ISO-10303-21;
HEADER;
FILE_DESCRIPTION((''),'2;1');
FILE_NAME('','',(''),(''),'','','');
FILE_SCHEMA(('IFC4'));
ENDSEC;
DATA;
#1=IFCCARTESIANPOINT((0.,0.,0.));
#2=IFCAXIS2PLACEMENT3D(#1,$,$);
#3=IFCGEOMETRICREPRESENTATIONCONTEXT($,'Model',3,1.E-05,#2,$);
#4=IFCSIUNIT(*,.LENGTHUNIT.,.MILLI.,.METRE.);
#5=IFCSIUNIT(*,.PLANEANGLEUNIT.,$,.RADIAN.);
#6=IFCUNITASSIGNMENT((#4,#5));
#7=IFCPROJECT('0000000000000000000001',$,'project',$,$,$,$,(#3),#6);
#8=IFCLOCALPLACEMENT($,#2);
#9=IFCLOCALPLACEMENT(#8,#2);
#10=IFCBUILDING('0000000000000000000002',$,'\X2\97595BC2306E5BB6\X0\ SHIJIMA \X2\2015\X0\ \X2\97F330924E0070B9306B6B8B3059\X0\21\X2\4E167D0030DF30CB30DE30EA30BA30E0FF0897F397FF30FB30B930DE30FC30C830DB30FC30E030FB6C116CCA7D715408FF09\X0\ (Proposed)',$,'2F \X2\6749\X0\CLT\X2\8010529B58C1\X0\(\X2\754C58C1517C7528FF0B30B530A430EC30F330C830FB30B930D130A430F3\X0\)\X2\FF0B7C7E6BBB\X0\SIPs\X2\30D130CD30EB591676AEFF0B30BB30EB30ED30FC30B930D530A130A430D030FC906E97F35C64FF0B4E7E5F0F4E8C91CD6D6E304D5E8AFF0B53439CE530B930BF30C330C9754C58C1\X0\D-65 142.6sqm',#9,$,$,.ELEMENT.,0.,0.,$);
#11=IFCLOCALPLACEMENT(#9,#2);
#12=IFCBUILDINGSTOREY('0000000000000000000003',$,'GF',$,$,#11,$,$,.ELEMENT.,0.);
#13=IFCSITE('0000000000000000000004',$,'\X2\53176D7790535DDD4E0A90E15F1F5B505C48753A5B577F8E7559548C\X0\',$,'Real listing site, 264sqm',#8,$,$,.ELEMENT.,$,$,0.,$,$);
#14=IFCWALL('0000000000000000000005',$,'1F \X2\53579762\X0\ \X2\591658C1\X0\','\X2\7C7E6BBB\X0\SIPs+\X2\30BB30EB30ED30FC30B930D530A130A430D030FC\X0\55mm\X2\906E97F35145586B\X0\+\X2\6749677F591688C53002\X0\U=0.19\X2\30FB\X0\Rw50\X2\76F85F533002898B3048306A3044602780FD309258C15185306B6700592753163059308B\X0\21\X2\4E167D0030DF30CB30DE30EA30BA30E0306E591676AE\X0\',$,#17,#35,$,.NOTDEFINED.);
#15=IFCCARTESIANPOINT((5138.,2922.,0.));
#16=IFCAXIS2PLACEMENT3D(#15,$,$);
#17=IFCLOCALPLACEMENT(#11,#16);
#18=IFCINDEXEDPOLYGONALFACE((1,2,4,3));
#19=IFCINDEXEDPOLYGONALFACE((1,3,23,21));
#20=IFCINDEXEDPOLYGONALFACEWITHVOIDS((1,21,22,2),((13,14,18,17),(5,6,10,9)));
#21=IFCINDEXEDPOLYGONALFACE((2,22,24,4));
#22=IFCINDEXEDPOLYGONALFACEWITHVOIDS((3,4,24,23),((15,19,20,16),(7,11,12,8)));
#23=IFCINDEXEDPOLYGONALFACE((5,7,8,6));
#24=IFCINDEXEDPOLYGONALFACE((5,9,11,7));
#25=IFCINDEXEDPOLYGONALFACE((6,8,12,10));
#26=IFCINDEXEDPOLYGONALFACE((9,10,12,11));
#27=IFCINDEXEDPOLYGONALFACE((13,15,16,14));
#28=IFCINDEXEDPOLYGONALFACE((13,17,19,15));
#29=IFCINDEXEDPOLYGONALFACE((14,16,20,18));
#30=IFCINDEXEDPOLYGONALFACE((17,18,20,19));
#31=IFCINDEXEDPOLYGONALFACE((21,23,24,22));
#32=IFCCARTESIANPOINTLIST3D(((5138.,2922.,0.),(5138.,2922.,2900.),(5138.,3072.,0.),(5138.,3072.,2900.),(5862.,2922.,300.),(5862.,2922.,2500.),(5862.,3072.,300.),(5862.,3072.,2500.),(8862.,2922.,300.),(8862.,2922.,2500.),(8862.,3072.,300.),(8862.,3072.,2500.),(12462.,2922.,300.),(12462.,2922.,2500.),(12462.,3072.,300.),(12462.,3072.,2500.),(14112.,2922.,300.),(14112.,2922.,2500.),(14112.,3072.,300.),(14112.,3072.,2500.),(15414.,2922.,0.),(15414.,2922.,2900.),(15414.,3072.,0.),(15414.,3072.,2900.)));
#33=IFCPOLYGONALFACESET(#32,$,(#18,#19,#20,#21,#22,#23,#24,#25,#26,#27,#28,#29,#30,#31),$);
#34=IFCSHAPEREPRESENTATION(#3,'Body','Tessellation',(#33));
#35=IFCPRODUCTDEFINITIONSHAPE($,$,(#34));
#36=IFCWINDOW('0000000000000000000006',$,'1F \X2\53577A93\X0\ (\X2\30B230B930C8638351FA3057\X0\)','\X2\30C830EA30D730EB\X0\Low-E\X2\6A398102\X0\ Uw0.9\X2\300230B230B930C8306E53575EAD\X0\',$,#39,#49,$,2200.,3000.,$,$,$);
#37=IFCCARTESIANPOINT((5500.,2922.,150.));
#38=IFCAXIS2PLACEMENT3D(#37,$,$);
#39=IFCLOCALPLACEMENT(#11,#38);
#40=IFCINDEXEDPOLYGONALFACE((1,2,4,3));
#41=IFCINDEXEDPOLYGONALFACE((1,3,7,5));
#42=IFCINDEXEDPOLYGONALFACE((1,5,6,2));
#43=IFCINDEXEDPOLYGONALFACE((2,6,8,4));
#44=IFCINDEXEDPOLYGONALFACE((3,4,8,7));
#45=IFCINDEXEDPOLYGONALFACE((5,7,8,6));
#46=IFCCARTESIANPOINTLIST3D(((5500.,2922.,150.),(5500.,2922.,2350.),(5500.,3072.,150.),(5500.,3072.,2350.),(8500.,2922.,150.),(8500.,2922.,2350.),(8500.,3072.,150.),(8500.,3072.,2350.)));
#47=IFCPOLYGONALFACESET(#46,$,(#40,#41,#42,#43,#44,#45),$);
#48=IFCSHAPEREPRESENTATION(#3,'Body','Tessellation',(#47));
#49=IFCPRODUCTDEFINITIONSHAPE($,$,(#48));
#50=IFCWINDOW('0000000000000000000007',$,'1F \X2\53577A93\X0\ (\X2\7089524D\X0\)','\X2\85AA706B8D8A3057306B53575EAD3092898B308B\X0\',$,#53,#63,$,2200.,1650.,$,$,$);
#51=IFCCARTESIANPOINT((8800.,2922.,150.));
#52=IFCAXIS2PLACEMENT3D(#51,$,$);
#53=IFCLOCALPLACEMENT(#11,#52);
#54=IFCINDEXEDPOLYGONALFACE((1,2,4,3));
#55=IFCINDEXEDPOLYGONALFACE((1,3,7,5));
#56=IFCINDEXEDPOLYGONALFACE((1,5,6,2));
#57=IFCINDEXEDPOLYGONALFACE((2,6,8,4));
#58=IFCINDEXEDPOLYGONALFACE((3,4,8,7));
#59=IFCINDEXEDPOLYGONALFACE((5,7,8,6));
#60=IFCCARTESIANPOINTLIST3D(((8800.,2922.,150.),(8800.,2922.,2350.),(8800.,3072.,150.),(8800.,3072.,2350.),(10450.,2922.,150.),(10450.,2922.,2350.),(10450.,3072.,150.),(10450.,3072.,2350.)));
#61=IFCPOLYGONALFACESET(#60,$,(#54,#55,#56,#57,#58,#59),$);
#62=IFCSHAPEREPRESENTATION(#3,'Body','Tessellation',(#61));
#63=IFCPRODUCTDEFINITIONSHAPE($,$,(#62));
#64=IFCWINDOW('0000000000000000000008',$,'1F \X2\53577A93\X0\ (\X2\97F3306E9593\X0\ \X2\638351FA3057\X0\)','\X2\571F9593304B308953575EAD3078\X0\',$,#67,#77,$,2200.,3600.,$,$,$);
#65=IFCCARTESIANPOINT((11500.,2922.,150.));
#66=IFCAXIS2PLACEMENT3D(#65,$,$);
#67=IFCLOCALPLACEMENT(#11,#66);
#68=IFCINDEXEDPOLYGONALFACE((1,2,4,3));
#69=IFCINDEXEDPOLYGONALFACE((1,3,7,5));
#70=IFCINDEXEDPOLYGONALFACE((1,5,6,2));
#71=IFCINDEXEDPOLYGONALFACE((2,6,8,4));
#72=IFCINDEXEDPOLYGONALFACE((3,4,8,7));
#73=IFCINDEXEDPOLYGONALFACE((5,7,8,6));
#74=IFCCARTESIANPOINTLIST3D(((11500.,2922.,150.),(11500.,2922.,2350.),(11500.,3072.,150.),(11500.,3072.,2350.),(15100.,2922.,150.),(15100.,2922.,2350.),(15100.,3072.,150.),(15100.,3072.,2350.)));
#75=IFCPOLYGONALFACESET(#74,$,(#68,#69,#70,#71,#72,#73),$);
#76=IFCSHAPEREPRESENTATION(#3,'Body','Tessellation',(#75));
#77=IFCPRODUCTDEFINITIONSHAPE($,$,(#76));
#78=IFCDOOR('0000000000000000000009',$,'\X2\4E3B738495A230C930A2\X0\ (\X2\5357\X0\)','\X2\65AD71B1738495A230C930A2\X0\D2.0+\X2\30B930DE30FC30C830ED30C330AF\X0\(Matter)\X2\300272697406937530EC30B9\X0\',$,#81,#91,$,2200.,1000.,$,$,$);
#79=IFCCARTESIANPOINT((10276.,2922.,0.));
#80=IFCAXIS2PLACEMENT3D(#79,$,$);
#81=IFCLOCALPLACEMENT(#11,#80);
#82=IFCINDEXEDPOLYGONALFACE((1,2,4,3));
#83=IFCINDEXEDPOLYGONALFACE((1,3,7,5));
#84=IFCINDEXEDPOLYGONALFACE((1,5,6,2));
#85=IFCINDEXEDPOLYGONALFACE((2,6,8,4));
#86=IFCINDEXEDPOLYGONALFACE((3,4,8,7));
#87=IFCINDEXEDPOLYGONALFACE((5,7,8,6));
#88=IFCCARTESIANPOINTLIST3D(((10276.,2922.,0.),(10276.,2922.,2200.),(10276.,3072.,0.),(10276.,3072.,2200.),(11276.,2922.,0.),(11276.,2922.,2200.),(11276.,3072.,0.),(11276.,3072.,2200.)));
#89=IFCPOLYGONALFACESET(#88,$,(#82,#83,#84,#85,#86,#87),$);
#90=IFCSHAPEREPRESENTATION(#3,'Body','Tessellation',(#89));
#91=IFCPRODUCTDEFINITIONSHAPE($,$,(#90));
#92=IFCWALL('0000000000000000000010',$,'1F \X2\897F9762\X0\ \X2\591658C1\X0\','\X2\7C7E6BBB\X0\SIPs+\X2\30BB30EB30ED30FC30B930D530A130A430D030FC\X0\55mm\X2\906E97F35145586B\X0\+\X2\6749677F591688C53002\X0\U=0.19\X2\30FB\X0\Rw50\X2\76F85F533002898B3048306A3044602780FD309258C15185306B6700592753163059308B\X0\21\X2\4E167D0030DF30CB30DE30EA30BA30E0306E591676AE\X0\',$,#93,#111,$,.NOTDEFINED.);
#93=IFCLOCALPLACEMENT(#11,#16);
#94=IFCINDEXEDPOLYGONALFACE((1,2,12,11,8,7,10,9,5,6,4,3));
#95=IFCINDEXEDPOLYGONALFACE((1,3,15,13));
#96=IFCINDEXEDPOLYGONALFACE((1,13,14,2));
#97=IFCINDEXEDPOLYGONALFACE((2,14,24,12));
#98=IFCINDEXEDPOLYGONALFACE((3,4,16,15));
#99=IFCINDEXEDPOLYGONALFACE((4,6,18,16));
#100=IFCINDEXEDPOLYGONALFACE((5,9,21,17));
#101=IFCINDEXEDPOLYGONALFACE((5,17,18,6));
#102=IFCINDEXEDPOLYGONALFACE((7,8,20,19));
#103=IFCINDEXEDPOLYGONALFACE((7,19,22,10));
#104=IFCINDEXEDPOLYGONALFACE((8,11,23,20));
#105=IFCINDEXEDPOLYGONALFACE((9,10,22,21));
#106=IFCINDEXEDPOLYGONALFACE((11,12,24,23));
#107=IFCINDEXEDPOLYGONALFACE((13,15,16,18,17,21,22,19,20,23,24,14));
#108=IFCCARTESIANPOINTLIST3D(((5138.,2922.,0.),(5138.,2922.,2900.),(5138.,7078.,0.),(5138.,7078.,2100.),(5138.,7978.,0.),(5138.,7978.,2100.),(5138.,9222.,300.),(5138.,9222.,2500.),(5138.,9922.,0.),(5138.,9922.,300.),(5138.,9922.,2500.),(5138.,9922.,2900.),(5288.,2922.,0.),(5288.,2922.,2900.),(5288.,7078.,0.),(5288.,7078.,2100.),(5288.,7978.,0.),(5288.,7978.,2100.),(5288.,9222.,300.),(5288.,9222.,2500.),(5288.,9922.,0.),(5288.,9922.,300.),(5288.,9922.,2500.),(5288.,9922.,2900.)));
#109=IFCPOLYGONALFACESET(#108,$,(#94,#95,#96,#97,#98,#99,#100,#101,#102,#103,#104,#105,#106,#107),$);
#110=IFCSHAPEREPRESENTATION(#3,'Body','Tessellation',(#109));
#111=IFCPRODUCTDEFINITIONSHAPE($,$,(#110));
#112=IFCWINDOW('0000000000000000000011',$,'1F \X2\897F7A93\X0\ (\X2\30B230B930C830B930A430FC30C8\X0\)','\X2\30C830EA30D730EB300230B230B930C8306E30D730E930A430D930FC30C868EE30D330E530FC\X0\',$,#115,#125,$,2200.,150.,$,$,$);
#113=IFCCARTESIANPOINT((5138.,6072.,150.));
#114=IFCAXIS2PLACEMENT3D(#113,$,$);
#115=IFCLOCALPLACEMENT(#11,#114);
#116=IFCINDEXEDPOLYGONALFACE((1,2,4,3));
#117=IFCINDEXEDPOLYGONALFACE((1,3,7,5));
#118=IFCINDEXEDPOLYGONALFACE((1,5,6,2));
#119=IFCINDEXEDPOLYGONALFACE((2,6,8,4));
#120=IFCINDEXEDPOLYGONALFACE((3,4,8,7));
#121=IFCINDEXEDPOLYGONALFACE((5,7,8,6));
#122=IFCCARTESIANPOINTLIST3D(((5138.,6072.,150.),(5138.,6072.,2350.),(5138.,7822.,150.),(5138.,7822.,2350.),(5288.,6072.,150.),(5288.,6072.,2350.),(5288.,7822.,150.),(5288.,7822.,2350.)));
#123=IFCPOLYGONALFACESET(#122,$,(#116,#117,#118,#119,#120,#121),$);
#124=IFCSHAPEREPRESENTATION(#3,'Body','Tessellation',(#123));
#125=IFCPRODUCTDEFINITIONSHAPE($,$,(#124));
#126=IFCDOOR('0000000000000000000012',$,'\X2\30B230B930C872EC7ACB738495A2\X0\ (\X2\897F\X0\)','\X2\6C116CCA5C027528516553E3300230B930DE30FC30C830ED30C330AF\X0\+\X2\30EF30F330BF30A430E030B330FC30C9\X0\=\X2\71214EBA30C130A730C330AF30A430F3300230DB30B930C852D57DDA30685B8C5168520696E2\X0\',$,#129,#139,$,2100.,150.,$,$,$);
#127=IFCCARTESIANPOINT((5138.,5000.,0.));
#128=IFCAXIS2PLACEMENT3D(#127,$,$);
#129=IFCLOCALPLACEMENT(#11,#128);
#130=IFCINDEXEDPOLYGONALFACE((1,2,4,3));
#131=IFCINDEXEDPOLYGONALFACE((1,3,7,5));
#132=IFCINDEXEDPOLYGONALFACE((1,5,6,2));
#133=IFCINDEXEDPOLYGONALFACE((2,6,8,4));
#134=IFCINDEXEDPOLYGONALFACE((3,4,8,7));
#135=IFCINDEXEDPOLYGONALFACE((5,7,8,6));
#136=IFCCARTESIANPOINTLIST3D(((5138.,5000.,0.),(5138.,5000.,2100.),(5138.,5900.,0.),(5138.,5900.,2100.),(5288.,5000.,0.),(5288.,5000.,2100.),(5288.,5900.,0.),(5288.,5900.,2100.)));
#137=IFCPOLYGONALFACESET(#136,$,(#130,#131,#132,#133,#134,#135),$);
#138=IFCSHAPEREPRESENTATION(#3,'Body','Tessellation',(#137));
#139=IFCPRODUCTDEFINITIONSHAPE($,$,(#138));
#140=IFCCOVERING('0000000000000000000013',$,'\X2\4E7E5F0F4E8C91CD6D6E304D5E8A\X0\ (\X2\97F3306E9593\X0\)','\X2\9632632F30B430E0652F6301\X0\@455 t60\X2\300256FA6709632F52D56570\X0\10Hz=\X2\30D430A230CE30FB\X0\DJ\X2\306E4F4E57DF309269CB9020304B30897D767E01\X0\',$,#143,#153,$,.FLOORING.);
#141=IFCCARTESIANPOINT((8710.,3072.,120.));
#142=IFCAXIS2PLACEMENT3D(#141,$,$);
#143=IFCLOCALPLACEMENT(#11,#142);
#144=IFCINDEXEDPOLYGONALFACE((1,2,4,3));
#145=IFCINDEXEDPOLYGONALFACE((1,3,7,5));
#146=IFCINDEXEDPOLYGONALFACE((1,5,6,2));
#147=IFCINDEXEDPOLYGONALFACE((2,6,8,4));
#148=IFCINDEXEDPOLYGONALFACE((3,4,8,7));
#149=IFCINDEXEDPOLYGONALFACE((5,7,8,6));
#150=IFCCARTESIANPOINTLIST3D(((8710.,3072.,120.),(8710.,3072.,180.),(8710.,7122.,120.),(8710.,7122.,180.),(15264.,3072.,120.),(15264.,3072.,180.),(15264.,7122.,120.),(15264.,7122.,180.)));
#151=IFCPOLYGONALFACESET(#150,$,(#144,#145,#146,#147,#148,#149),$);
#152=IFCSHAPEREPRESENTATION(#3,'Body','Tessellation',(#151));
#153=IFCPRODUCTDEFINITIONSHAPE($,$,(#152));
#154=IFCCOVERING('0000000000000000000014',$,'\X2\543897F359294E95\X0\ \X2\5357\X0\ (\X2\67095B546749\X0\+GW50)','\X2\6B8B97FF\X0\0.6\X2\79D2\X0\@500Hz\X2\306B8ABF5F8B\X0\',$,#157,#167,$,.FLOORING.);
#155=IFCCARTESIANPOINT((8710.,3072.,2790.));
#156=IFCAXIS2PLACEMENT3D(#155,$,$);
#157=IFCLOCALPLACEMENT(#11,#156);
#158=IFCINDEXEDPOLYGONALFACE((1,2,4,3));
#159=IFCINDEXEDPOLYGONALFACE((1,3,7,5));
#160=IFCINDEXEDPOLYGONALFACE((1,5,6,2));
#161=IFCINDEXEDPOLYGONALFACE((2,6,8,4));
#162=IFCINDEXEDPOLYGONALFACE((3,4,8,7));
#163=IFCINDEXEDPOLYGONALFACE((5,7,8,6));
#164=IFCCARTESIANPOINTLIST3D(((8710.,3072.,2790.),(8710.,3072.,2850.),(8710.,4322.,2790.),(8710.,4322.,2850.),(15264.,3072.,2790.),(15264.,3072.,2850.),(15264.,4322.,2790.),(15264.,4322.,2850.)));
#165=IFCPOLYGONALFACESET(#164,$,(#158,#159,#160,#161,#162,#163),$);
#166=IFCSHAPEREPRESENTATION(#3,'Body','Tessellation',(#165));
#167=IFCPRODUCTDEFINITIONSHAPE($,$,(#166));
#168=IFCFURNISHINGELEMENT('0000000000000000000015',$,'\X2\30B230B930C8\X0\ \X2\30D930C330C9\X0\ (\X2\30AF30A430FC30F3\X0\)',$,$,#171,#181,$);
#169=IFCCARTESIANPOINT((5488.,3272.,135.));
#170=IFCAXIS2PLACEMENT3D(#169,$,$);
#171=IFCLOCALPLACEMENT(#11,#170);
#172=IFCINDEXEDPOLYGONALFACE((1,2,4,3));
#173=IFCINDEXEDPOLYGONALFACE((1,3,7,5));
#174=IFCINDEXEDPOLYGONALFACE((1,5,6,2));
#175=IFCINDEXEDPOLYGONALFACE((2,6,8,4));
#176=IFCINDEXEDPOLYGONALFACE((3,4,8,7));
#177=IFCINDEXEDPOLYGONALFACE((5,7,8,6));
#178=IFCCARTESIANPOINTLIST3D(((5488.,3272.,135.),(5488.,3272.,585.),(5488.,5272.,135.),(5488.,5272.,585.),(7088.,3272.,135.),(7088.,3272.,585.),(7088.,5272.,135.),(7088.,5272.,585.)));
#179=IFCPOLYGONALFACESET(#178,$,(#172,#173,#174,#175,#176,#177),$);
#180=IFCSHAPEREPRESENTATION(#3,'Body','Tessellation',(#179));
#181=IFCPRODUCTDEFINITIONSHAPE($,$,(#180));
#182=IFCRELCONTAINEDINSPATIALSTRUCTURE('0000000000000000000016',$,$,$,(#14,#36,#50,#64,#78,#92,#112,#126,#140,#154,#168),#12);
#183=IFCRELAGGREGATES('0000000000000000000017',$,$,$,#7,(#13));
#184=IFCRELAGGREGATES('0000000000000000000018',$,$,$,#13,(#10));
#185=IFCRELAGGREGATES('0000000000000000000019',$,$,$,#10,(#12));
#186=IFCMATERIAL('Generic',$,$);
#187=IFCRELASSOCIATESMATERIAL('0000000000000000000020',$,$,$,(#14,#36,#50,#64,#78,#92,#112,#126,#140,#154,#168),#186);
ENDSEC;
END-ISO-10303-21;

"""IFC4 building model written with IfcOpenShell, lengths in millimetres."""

from ifc_helpers import new_model, si_unit, frame, frame_2d, origin, place, context, project, spatial, rectangle, extrude, material, element, fill, save


model = new_model("IFC4")

# Units and contexts
model_context = context("Model", 3, precision=1e-05, world=origin())
ifc_project = project(units=[si_unit("LENGTHUNIT", "METRE", prefix="MILLI"), si_unit("PLANEANGLEUNIT", "RADIAN")], contexts=[model_context])

# Site, building, storey
site_placement = place(None, origin())
site = spatial("IfcSite", under=ifc_project, at=site_placement, Name="北海道川上郡弟子屈町字美留和", ObjectType="Real listing site, 264sqm", CompositionType="ELEMENT", RefElevation=0.0)
building_placement = place(site_placement, origin())
building = spatial("IfcBuilding", under=site, at=building_placement, Name="静寂の家 SHIJIMA ― 音を一点に残す21世紀ミニマリズム（音響・スマートホーム・民泊統合） (Proposed)", ObjectType="2F 杉CLT耐力壁(界壁兼用＋サイレント・スパイン)＋籾殻SIPsパネル外皮＋セルロースファイバー遮音層＋乾式二重浮き床＋千鳥スタッド界壁D-65 142.6sqm", CompositionType="ELEMENT", ElevationOfRefHeight=0.0, ElevationOfTerrain=0.0)
storey_placement = place(building_placement, origin())
storey = spatial("IfcBuildingStorey", under=building, at=storey_placement, Name="GF", CompositionType="ELEMENT", Elevation=0.0)

# Shared definitions
ifc_material_1 = material(Name="Generic")

# Wall, openings, windows, door
wall_1_placement = place(storey_placement, frame((5138.0, 2922.0, 0.0)))
wall_1 = element("IfcWall", 1, at=wall_1_placement, inside=storey, material=ifc_material_1, Name="1F 南面 外壁", Description="籾殻SIPs+セルロースファイバー55mm遮音充填+杉板外装。U=0.19・Rw50相当。見えない性能を壁内に最大化する21世紀ミニマリズムの外皮", PredefinedType="NOTDEFINED", context=model_context, shape_type="SweptSolid", body=[
    extrude(rectangle(XDim=10276.0, YDim=150.0, at=frame_2d((5138.0, 75.0))), frame((5138.0, 2922.0, 0.0)), (0.0, 0.0, 1.0), 2900.0),
])
opening_1_placement = place(storey_placement, frame((5500.0, 2922.0, 150.0)))
opening_1 = element("IfcOpeningElement", 2, at=opening_1_placement, cuts=wall_1, PredefinedType="NOTDEFINED", context=model_context, shape_type="SweptSolid", body=[
    extrude(rectangle(XDim=3000.0, YDim=150.0, at=frame_2d((1500.0, 75.0))), frame((5500.0, 2922.0, 150.0)), (0.0, 0.0, 1.0), 2200.0),
])
opening_2_placement = place(storey_placement, frame((8800.0, 2922.0, 150.0)))
opening_2 = element("IfcOpeningElement", 3, at=opening_2_placement, cuts=wall_1, PredefinedType="NOTDEFINED", context=model_context, shape_type="SweptSolid", body=[
    extrude(rectangle(XDim=1650.0, YDim=150.0, at=frame_2d((825.0, 75.0))), frame((8800.0, 2922.0, 150.0)), (0.0, 0.0, 1.0), 2200.0),
])
opening_3_placement = place(storey_placement, frame((11500.0, 2922.0, 150.0)))
opening_3 = element("IfcOpeningElement", 4, at=opening_3_placement, cuts=wall_1, PredefinedType="NOTDEFINED", context=model_context, shape_type="SweptSolid", body=[
    extrude(rectangle(XDim=3600.0, YDim=150.0, at=frame_2d((1800.0, 75.0))), frame((11500.0, 2922.0, 150.0)), (0.0, 0.0, 1.0), 2200.0),
])
opening_4_placement = place(storey_placement, frame((10276.0, 2922.0, 0.0)))
opening_4 = element("IfcOpeningElement", 5, at=opening_4_placement, cuts=wall_1, PredefinedType="NOTDEFINED", context=model_context, shape_type="SweptSolid", body=[
    extrude(rectangle(XDim=1000.0, YDim=150.0, at=frame_2d((500.0, 75.0))), frame((10276.0, 2922.0, 0.0)), (0.0, 0.0, 1.0), 2200.0),
])
window_1_placement = place(storey_placement, frame((5500.0, 2922.0, 150.0)))
window_1 = element("IfcWindow", 6, at=window_1_placement, inside=storey, material=ifc_material_1, Name="1F 南窓 (ゲスト掃出し)", Description="トリプルLow-E樹脂 Uw0.9。ゲストの南庭", OverallHeight=2200.0, OverallWidth=3000.0, context=model_context, shape_type="SweptSolid", body=[
    extrude(rectangle(XDim=3000.0, YDim=150.0, at=frame_2d((1500.0, 75.0))), frame((5500.0, 2922.0, 150.0)), (0.0, 0.0, 1.0), 2200.0),
])
fill(opening_1, window_1)
window_2_placement = place(storey_placement, frame((8800.0, 2922.0, 150.0)))
window_2 = element("IfcWindow", 7, at=window_2_placement, inside=storey, material=ifc_material_1, Name="1F 南窓 (炉前)", Description="薪火越しに南庭を見る", OverallHeight=2200.0, OverallWidth=1650.0, context=model_context, shape_type="SweptSolid", body=[
    extrude(rectangle(XDim=1650.0, YDim=150.0, at=frame_2d((825.0, 75.0))), frame((8800.0, 2922.0, 150.0)), (0.0, 0.0, 1.0), 2200.0),
])
fill(opening_2, window_2)
window_3_placement = place(storey_placement, frame((11500.0, 2922.0, 150.0)))
window_3 = element("IfcWindow", 8, at=window_3_placement, inside=storey, material=ifc_material_1, Name="1F 南窓 (音の間 掃出し)", Description="土間から南庭へ", OverallHeight=2200.0, OverallWidth=3600.0, context=model_context, shape_type="SweptSolid", body=[
    extrude(rectangle(XDim=3600.0, YDim=150.0, at=frame_2d((1800.0, 75.0))), frame((11500.0, 2922.0, 150.0)), (0.0, 0.0, 1.0), 2200.0),
])
fill(opening_3, window_3)
door_1_placement = place(storey_placement, frame((10276.0, 2922.0, 0.0)))
door_1 = element("IfcDoor", 9, at=door_1_placement, inside=storey, material=ifc_material_1, Name="主玄関ドア (南)", Description="断熱玄関ドアD2.0+スマートロック(Matter)。物理鍵レス", OverallHeight=2200.0, OverallWidth=1000.0, context=model_context, shape_type="SweptSolid", body=[
    extrude(rectangle(XDim=1000.0, YDim=150.0, at=frame_2d((500.0, 75.0))), frame((10276.0, 2922.0, 0.0)), (0.0, 0.0, 1.0), 2200.0),
])
fill(opening_4, door_1)

# Wall, openings, window, door
wall_2_placement = place(storey_placement, frame((5138.0, 2922.0, 0.0)))
wall_2 = element("IfcWall", 10, at=wall_2_placement, inside=storey, material=ifc_material_1, Name="1F 西面 外壁", Description="籾殻SIPs+セルロースファイバー55mm遮音充填+杉板外装。U=0.19・Rw50相当。見えない性能を壁内に最大化する21世紀ミニマリズムの外皮", PredefinedType="NOTDEFINED", context=model_context, shape_type="SweptSolid", body=[
    extrude(rectangle(XDim=150.0, YDim=7000.0, at=frame_2d((75.0, 3500.0))), frame((5138.0, 2922.0, 0.0)), (0.0, 0.0, 1.0), 2900.0),
])
opening_5_placement = place(storey_placement, frame((5138.0, 6072.0, 150.0)))
opening_5 = element("IfcOpeningElement", 11, at=opening_5_placement, cuts=wall_2, PredefinedType="NOTDEFINED", context=model_context, shape_type="SweptSolid", body=[
    extrude(rectangle(XDim=150.0, YDim=1750.0, at=frame_2d((75.0, 875.0))), frame((5138.0, 6072.0, 150.0)), (0.0, 0.0, 1.0), 2200.0),
])
opening_6_placement = place(storey_placement, frame((5138.0, 5000.0, 0.0)))
opening_6 = element("IfcOpeningElement", 12, at=opening_6_placement, cuts=wall_2, PredefinedType="NOTDEFINED", context=model_context, shape_type="SweptSolid", body=[
    extrude(rectangle(XDim=150.0, YDim=900.0, at=frame_2d((75.0, 450.0))), frame((5138.0, 5000.0, 0.0)), (0.0, 0.0, 1.0), 2100.0),
])
window_4_placement = place(storey_placement, frame((5138.0, 6072.0, 150.0)))
window_4 = element("IfcWindow", 13, at=window_4_placement, inside=storey, material=ifc_material_1, Name="1F 西窓 (ゲストスイート)", Description="トリプル。ゲストのプライベート森ビュー", OverallHeight=2200.0, OverallWidth=150.0, context=model_context, shape_type="SweptSolid", body=[
    extrude(rectangle(XDim=150.0, YDim=1750.0, at=frame_2d((75.0, 875.0))), frame((5138.0, 6072.0, 150.0)), (0.0, 0.0, 1.0), 2200.0),
])
fill(opening_5, window_4)
door_2_placement = place(storey_placement, frame((5138.0, 5000.0, 0.0)))
door_2 = element("IfcDoor", 14, at=door_2_placement, inside=storey, material=ifc_material_1, Name="ゲスト独立玄関 (西)", Description="民泊専用入口。スマートロック+ワンタイムコード=無人チェックイン。ホスト動線と完全分離", OverallHeight=2100.0, OverallWidth=150.0, context=model_context, shape_type="SweptSolid", body=[
    extrude(rectangle(XDim=150.0, YDim=900.0, at=frame_2d((75.0, 450.0))), frame((5138.0, 5000.0, 0.0)), (0.0, 0.0, 1.0), 2100.0),
])
fill(opening_6, door_2)

# Coverings
covering_1_placement = place(storey_placement, frame((8710.0, 3072.0, 120.0)))
element("IfcCovering", 15, at=covering_1_placement, inside=storey, material=ifc_material_1, Name="乾式二重浮き床 (音の間)", Description="防振ゴム支持@455 t60。固有振動数10Hz=ピアノ・DJの低域を構造から絶縁", PredefinedType="FLOORING", context=model_context, shape_type="SweptSolid", body=[
    extrude(rectangle(XDim=6554.0, YDim=4050.0, at=frame_2d((3277.0, 2025.0))), frame((8710.0, 3072.0, 120.0)), (0.0, 0.0, 1.0), 60.0),
])
covering_2_placement = place(storey_placement, frame((8710.0, 3072.0, 2790.0)))
element("IfcCovering", 16, at=covering_2_placement, inside=storey, material=ifc_material_1, Name="吸音天井 南 (有孔杉+GW50)", Description="残響0.6秒@500Hzに調律", PredefinedType="FLOORING", context=model_context, shape_type="SweptSolid", body=[
    extrude(rectangle(XDim=6554.0, YDim=1250.0, at=frame_2d((3277.0, 625.0))), frame((8710.0, 3072.0, 2790.0)), (0.0, 0.0, 1.0), 60.0),
])

# Furnishing element
furnishing_1_placement = place(storey_placement, frame((5488.0, 3272.0, 135.0)))
element("IfcFurnishingElement", 17, at=furnishing_1_placement, inside=storey, material=ifc_material_1, Name="ゲスト ベッド (クイーン)", context=model_context, shape_type="SweptSolid", body=[
    extrude(rectangle(XDim=1600.0, YDim=2000.0, at=frame_2d((800.0, 1000.0))), frame((5488.0, 3272.0, 135.0)), (0.0, 0.0, 1.0), 450.0),
])

save(model, "model.ifc")
